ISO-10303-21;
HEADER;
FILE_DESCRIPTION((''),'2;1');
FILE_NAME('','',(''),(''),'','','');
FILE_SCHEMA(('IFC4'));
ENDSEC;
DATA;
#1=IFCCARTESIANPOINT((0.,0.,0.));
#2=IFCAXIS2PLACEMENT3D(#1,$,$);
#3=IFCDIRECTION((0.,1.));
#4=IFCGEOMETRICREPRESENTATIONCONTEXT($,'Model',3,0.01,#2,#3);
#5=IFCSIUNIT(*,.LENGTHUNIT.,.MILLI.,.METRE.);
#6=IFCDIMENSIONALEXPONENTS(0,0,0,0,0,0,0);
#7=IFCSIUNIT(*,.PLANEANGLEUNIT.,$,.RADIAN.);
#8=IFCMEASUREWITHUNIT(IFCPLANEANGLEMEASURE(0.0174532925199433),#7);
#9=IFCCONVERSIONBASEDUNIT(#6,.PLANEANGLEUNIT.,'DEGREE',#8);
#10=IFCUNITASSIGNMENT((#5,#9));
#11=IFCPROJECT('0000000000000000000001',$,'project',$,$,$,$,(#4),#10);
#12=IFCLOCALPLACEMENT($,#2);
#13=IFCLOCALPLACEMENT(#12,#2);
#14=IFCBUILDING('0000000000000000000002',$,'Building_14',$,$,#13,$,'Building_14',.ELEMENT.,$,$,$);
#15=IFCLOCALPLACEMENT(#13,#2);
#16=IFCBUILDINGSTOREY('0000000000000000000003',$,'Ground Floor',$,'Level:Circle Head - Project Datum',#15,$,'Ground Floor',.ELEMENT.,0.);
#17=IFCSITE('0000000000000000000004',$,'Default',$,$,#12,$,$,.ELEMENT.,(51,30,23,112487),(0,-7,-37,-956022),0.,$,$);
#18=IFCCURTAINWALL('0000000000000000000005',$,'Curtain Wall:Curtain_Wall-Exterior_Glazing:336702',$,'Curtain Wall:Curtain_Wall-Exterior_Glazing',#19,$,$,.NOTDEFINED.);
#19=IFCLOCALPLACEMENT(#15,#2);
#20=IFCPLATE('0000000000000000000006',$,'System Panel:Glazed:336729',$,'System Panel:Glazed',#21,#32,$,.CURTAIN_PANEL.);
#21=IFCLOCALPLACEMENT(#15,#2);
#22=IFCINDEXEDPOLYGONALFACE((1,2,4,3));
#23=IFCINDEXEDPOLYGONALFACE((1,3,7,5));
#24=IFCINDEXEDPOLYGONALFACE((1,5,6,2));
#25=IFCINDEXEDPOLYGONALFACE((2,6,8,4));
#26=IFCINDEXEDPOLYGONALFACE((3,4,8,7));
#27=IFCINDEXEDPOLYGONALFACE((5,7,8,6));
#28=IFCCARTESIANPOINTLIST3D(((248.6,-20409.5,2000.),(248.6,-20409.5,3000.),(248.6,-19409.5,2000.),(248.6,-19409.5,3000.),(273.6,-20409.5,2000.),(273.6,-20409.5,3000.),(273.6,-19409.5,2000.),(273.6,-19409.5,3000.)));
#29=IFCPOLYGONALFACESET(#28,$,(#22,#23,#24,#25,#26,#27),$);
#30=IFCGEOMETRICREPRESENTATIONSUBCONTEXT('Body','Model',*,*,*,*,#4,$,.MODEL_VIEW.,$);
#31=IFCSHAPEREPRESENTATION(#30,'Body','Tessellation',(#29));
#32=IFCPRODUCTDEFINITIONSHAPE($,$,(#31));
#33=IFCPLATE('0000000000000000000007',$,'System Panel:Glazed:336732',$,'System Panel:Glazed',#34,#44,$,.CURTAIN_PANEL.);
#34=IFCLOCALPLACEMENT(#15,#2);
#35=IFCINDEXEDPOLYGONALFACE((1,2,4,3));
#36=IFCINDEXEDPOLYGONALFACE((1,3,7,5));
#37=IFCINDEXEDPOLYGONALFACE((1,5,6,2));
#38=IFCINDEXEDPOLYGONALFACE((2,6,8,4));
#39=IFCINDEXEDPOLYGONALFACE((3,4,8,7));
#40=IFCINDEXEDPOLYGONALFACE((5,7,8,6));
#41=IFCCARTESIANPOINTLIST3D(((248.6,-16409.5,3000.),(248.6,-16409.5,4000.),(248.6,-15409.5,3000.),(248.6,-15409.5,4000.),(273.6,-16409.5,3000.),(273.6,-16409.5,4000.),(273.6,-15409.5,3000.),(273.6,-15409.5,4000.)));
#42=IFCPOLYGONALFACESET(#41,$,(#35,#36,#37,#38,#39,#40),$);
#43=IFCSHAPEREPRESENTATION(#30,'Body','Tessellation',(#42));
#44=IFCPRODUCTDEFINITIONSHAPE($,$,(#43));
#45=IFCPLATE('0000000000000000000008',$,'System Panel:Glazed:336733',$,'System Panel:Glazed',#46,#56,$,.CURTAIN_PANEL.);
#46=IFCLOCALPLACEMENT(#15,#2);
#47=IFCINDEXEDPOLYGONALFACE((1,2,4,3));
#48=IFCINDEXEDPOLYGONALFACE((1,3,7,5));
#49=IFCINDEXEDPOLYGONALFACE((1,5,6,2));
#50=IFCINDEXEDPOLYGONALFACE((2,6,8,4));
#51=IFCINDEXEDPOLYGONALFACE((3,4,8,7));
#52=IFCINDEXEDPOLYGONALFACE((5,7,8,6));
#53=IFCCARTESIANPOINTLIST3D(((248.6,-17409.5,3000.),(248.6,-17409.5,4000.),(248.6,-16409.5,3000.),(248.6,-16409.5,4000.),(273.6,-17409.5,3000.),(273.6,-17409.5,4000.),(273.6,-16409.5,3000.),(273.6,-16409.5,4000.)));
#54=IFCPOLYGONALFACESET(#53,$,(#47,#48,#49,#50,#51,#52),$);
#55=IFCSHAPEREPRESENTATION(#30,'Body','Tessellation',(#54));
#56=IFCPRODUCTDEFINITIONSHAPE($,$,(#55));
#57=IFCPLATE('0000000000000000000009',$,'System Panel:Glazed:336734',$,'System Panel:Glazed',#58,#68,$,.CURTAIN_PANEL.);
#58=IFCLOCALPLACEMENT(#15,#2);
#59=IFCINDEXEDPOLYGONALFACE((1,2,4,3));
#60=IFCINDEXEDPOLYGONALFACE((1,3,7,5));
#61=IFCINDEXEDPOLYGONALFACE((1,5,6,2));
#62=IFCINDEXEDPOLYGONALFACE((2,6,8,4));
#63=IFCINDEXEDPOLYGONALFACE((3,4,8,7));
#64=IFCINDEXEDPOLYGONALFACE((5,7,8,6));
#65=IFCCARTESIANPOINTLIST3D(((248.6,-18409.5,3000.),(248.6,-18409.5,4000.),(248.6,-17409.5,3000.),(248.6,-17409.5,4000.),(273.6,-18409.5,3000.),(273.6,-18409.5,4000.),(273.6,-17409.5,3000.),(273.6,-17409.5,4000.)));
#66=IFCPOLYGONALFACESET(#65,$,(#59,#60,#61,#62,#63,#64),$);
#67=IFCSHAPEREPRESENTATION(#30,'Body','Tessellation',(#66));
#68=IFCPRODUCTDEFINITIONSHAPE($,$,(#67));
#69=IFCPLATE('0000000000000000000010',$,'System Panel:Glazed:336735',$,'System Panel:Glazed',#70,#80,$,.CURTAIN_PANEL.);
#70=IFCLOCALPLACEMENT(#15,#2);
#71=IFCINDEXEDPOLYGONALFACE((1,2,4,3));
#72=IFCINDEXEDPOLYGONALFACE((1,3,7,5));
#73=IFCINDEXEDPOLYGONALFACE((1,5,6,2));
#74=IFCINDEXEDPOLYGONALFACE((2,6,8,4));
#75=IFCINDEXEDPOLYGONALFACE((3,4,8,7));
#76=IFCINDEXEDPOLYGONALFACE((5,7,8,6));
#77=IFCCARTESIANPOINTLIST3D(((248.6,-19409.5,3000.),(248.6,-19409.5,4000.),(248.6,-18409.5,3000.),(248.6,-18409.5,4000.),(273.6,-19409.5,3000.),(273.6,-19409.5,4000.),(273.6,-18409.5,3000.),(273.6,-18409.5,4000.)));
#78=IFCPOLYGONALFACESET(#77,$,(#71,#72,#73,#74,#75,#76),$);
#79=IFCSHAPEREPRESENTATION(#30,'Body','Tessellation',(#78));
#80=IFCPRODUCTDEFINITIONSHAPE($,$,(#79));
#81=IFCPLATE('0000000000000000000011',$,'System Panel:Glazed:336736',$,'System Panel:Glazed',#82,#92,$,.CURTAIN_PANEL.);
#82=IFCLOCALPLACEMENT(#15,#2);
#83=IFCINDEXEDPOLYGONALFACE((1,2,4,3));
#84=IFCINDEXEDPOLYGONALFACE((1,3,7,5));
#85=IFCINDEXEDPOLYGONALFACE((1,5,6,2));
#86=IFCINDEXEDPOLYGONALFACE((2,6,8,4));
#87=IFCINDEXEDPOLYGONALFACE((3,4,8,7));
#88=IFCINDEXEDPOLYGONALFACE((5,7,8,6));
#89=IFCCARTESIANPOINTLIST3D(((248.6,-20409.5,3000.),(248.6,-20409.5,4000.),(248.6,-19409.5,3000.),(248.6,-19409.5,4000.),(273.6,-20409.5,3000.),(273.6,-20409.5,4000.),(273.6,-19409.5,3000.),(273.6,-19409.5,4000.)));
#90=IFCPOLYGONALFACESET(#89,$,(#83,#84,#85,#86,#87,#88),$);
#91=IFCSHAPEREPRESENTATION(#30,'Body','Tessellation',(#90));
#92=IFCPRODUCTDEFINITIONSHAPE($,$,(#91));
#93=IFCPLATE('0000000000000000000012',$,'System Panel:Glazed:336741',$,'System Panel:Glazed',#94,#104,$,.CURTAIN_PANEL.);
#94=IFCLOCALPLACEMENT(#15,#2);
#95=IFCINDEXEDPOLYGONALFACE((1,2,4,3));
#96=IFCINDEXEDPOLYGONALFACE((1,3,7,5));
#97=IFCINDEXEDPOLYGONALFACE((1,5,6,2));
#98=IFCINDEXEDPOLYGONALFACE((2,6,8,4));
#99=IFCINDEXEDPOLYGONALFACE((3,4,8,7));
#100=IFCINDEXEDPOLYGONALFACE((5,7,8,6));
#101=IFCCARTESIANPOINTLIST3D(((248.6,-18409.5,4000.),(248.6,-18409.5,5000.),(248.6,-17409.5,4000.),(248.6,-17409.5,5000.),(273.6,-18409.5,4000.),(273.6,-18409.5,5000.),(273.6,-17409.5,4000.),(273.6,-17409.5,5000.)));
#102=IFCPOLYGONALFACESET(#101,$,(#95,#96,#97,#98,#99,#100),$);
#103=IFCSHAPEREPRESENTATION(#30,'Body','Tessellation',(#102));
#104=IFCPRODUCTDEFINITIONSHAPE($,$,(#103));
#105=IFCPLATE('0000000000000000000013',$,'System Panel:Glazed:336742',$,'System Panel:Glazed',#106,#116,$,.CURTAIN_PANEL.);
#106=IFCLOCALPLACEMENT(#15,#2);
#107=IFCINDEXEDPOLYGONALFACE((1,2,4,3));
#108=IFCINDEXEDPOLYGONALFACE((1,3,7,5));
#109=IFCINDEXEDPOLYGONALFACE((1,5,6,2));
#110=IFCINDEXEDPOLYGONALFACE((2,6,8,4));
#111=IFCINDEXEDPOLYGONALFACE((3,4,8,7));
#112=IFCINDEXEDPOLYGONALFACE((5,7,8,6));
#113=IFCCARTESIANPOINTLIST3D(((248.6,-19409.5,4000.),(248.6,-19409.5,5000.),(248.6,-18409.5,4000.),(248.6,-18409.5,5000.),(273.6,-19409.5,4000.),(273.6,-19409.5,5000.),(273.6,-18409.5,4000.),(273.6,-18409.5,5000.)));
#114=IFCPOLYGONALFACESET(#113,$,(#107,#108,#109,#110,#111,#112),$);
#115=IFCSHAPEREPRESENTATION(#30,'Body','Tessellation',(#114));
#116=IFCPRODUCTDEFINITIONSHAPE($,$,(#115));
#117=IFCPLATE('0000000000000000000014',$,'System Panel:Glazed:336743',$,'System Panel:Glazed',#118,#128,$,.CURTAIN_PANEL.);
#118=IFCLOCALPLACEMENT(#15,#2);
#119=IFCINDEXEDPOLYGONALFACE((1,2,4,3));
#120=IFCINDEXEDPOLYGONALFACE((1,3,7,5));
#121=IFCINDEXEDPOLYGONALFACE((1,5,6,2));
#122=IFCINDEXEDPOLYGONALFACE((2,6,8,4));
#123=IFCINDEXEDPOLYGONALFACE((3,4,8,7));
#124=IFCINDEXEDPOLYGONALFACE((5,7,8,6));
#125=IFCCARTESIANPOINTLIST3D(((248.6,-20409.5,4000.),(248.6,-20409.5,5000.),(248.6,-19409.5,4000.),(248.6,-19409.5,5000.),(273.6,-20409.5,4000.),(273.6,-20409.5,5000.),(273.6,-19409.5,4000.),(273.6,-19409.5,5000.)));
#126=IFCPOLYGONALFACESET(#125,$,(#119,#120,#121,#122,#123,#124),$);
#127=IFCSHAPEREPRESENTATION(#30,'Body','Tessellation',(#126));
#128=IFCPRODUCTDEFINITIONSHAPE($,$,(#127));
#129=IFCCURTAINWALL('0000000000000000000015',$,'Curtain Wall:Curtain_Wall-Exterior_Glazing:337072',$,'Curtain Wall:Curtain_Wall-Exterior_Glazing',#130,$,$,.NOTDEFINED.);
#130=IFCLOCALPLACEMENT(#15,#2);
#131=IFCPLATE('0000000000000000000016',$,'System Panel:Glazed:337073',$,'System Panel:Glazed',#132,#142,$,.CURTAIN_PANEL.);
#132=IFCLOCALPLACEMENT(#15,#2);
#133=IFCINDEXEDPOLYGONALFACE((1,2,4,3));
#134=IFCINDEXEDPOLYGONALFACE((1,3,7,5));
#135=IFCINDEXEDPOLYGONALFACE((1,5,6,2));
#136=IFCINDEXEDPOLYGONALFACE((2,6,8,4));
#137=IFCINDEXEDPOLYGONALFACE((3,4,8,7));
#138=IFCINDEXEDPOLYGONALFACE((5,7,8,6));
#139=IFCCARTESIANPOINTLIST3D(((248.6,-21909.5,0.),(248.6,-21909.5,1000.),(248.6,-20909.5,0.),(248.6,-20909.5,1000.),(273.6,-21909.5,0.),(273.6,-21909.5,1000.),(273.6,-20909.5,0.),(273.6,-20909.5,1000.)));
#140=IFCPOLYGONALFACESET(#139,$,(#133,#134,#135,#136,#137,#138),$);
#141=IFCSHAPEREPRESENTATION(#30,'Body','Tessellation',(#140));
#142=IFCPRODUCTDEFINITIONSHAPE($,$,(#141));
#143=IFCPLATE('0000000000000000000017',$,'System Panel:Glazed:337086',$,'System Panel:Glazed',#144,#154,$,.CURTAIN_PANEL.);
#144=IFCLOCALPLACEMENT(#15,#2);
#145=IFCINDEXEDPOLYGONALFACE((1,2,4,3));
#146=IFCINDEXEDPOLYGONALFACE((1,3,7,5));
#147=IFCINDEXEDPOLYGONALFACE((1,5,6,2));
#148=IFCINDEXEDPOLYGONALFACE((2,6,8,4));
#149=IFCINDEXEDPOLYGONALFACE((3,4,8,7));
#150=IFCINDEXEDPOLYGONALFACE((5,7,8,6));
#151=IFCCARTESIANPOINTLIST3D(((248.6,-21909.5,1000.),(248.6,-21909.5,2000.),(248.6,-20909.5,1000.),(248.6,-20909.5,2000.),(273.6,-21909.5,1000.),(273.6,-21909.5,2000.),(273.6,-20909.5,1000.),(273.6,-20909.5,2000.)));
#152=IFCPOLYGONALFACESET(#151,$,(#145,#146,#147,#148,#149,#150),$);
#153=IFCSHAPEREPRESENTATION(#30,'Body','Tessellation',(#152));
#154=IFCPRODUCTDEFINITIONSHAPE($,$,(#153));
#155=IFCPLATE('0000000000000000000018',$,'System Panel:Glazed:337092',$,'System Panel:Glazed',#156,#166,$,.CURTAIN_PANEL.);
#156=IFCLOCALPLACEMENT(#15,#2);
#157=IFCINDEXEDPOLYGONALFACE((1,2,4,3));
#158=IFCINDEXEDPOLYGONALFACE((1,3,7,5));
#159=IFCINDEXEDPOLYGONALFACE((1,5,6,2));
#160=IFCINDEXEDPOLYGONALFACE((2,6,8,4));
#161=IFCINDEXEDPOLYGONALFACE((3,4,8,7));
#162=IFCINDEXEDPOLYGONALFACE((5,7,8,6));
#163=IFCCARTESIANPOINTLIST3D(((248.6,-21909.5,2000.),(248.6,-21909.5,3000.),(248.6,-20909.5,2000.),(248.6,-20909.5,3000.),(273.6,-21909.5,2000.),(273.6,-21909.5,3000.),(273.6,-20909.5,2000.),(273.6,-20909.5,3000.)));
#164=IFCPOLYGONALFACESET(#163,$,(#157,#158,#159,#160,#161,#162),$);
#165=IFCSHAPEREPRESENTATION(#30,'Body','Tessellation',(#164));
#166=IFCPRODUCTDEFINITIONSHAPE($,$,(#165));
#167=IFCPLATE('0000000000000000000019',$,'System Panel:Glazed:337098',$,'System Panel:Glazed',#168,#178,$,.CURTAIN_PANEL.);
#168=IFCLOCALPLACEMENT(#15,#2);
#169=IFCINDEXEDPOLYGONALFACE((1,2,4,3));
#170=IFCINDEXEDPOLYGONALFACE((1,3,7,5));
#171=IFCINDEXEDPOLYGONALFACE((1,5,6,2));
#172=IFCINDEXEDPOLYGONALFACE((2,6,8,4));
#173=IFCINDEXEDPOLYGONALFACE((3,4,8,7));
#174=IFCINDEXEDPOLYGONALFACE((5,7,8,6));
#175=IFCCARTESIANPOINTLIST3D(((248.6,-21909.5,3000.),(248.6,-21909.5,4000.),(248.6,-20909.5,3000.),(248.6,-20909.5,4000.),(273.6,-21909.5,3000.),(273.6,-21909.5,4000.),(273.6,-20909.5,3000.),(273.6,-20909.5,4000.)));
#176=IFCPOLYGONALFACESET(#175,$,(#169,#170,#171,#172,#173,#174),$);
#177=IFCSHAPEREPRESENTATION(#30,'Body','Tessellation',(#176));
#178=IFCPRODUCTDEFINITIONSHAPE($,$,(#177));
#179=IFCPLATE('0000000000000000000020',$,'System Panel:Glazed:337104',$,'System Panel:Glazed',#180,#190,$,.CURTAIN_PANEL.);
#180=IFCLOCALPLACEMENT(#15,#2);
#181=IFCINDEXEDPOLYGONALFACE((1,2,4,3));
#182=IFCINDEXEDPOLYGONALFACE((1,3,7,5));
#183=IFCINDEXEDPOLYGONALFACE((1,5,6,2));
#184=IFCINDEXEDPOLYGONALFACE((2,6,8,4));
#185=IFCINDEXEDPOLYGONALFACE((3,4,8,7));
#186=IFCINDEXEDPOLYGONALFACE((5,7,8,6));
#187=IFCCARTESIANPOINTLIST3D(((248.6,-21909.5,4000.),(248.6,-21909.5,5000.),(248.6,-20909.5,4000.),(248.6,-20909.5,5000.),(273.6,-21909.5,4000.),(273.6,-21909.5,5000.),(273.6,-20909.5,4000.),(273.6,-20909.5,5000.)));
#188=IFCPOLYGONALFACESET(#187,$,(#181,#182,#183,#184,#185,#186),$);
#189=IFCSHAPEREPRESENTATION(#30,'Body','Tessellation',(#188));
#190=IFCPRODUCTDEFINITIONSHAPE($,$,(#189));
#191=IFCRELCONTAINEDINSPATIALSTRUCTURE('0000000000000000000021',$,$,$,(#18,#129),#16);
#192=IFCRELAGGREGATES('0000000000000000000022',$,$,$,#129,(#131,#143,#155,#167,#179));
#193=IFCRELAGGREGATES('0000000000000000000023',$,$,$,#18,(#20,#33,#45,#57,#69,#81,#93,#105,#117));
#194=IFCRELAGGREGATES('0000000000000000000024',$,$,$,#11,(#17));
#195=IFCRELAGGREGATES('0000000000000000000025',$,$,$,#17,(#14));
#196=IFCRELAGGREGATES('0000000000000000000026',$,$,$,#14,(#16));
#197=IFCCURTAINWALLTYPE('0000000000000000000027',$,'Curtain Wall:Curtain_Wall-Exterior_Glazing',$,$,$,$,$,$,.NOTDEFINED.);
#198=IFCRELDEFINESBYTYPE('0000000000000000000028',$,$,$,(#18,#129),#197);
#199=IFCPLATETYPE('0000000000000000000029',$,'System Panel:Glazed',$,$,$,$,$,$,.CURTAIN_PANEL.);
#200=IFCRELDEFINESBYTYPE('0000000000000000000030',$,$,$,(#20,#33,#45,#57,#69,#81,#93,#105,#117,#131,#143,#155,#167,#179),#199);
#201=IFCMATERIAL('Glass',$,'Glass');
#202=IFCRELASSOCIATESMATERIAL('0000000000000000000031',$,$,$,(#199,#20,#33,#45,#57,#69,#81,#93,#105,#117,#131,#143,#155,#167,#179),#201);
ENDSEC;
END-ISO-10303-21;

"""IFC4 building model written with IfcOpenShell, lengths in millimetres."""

from ifc_helpers import new_model, entity, si_unit, converted_unit, direction, frame, origin, place, context, subcontext, project, spatial, indexed_curve, outline, extrude, source, transform, mapped, material, type_object, type_shapes, element, aggregate, save


model = new_model("IFC4")

# Units and contexts
model_context = context("Model", 3, precision=0.01, world=origin(), true_north=direction((0.0, 1.0)))
body_context = subcontext(model_context, "Body", "Model", "MODEL_VIEW")
ifc_project = project(units=[si_unit("LENGTHUNIT", "METRE", prefix="MILLI"), converted_unit("PLANEANGLEUNIT", "DEGREE", entity("IfcPlaneAngleMeasure", 0.0174532925199433), si_unit("PLANEANGLEUNIT", "RADIAN"), dimensions=[0, 0, 0, 0, 0, 0, 0])], contexts=[model_context])

# Site, building, storey
site_placement = place(None, origin())
site = spatial("IfcSite", under=ifc_project, at=site_placement, Name="Default", CompositionType="ELEMENT", RefLatitude=(51, 30, 23, 112487), RefLongitude=(0, -7, -37, -956022), RefElevation=0.0)
building_placement = place(site_placement, origin())
building = spatial("IfcBuilding", under=site, at=building_placement, Name="Building_14", LongName="Building_14", CompositionType="ELEMENT")
storey_placement = place(building_placement, origin())
storey = spatial("IfcBuildingStorey", under=building, at=storey_placement, Name="Ground Floor", ObjectType="Level:Circle Head - Project Datum", LongName="Ground Floor", CompositionType="ELEMENT", Elevation=0.0)

# Curtain walls, plates
curtain_wall_type = type_object("IfcCurtainWallType", Name="Curtain Wall:Curtain_Wall-Exterior_Glazing", PredefinedType="NOTDEFINED")
curtain_wall_1_placement = place(storey_placement, origin())
curtain_wall_1 = element("IfcCurtainWall", 1, at=curtain_wall_1_placement, inside=storey, type_object=curtain_wall_type, Name="Curtain Wall:Curtain_Wall-Exterior_Glazing:336702", ObjectType="Curtain Wall:Curtain_Wall-Exterior_Glazing", PredefinedType="NOTDEFINED")
ifc_material = material(Name="Glass", Category="Glass")
plate_type_1 = type_object("IfcPlateType", Name="System Panel:Glazed", PredefinedType="CURTAIN_PANEL", material=ifc_material)
shared_shape_1 = source(origin(), body_context, "Body", "SweptSolid", [
    extrude(outline(indexed_curve([(-12.5, -500.0), (12.5, -500.0), (12.5, 500.0), (-12.5, 500.0), (-12.5, -500.0)], self_intersect=False)), frame((0.0, -37.0, 0.0), z_axis=(0.0, 0.0, 1.0), x_axis=(0.0, 1.0, 0.0)), (0.0, 0.0, 1.0), 1000.0),
])
type_shapes(plate_type_1, [shared_shape_1])
plate_1_placement = place(curtain_wall_1_placement, frame((298.1, -19909.5, 2000.0), z_axis=(0.0, 0.0, 1.0), x_axis=(0.0, -1.0, 0.0)))
plate_1 = element("IfcPlate", 2, at=plate_1_placement, type_object=plate_type_1, material=ifc_material, Name="System Panel:Glazed:336729", ObjectType="System Panel:Glazed", PredefinedType="CURTAIN_PANEL", context=body_context, shape_type="MappedRepresentation", body=[
    mapped(shared_shape_1, transform((0.0, 0.0, 0.0), scale=1.0)),
])
plate_2_placement = place(curtain_wall_1_placement, frame((298.1, -15909.5, 3000.0), z_axis=(0.0, 0.0, 1.0), x_axis=(0.0, -1.0, 0.0)))
plate_2 = element("IfcPlate", 3, at=plate_2_placement, type_object=plate_type_1, material=ifc_material, Name="System Panel:Glazed:336732", ObjectType="System Panel:Glazed", PredefinedType="CURTAIN_PANEL", context=body_context, shape_type="MappedRepresentation", body=[
    mapped(shared_shape_1, transform((0.0, 0.0, 0.0), scale=1.0)),
])
plate_3_placement = place(curtain_wall_1_placement, frame((298.1, -16909.5, 3000.0), z_axis=(0.0, 0.0, 1.0), x_axis=(0.0, -1.0, 0.0)))
plate_3 = element("IfcPlate", 4, at=plate_3_placement, type_object=plate_type_1, material=ifc_material, Name="System Panel:Glazed:336733", ObjectType="System Panel:Glazed", PredefinedType="CURTAIN_PANEL", context=body_context, shape_type="MappedRepresentation", body=[
    mapped(shared_shape_1, transform((0.0, 0.0, 0.0), scale=1.0)),
])
plate_4_placement = place(curtain_wall_1_placement, frame((298.1, -17909.5, 3000.0), z_axis=(0.0, 0.0, 1.0), x_axis=(0.0, -1.0, 0.0)))
plate_4 = element("IfcPlate", 5, at=plate_4_placement, type_object=plate_type_1, material=ifc_material, Name="System Panel:Glazed:336734", ObjectType="System Panel:Glazed", PredefinedType="CURTAIN_PANEL", context=body_context, shape_type="MappedRepresentation", body=[
    mapped(shared_shape_1, transform((0.0, 0.0, 0.0), scale=1.0)),
])
plate_5_placement = place(curtain_wall_1_placement, frame((298.1, -18909.5, 3000.0), z_axis=(0.0, 0.0, 1.0), x_axis=(0.0, -1.0, 0.0)))
plate_5 = element("IfcPlate", 6, at=plate_5_placement, type_object=plate_type_1, material=ifc_material, Name="System Panel:Glazed:336735", ObjectType="System Panel:Glazed", PredefinedType="CURTAIN_PANEL", context=body_context, shape_type="MappedRepresentation", body=[
    mapped(shared_shape_1, transform((0.0, 0.0, 0.0), scale=1.0)),
])
plate_6_placement = place(curtain_wall_1_placement, frame((298.1, -19909.5, 3000.0), z_axis=(0.0, 0.0, 1.0), x_axis=(0.0, -1.0, 0.0)))
plate_6 = element("IfcPlate", 7, at=plate_6_placement, type_object=plate_type_1, material=ifc_material, Name="System Panel:Glazed:336736", ObjectType="System Panel:Glazed", PredefinedType="CURTAIN_PANEL", context=body_context, shape_type="MappedRepresentation", body=[
    mapped(shared_shape_1, transform((0.0, 0.0, 0.0), scale=1.0)),
])
plate_7_placement = place(curtain_wall_1_placement, frame((298.1, -17909.5, 4000.0), z_axis=(0.0, 0.0, 1.0), x_axis=(0.0, -1.0, 0.0)))
plate_7 = element("IfcPlate", 8, at=plate_7_placement, type_object=plate_type_1, material=ifc_material, Name="System Panel:Glazed:336741", ObjectType="System Panel:Glazed", PredefinedType="CURTAIN_PANEL", context=body_context, shape_type="MappedRepresentation", body=[
    mapped(shared_shape_1, transform((0.0, 0.0, 0.0), scale=1.0)),
])
plate_8_placement = place(curtain_wall_1_placement, frame((298.1, -18909.5, 4000.0), z_axis=(0.0, 0.0, 1.0), x_axis=(0.0, -1.0, 0.0)))
plate_8 = element("IfcPlate", 9, at=plate_8_placement, type_object=plate_type_1, material=ifc_material, Name="System Panel:Glazed:336742", ObjectType="System Panel:Glazed", PredefinedType="CURTAIN_PANEL", context=body_context, shape_type="MappedRepresentation", body=[
    mapped(shared_shape_1, transform((0.0, 0.0, 0.0), scale=1.0)),
])
plate_9_placement = place(curtain_wall_1_placement, frame((298.1, -19909.5, 4000.0), z_axis=(0.0, 0.0, 1.0), x_axis=(0.0, -1.0, 0.0)))
plate_9 = element("IfcPlate", 10, at=plate_9_placement, type_object=plate_type_1, material=ifc_material, Name="System Panel:Glazed:336743", ObjectType="System Panel:Glazed", PredefinedType="CURTAIN_PANEL", context=body_context, shape_type="MappedRepresentation", body=[
    mapped(shared_shape_1, transform((0.0, 0.0, 0.0), scale=1.0)),
])
curtain_wall_2_placement = place(storey_placement, origin())
curtain_wall_2 = element("IfcCurtainWall", 11, at=curtain_wall_2_placement, inside=storey, type_object=curtain_wall_type, Name="Curtain Wall:Curtain_Wall-Exterior_Glazing:337072", ObjectType="Curtain Wall:Curtain_Wall-Exterior_Glazing", PredefinedType="NOTDEFINED")
plate_10_placement = place(curtain_wall_2_placement, frame((298.1, -21409.5, 0.0), z_axis=(0.0, 0.0, 1.0), x_axis=(0.0, -1.0, 0.0)))
plate_10 = element("IfcPlate", 12, at=plate_10_placement, type_object=plate_type_1, material=ifc_material, Name="System Panel:Glazed:337073", ObjectType="System Panel:Glazed", PredefinedType="CURTAIN_PANEL", context=body_context, shape_type="MappedRepresentation", body=[
    mapped(shared_shape_1, transform((0.0, 0.0, 0.0), scale=1.0)),
])
plate_11_placement = place(curtain_wall_2_placement, frame((298.1, -21409.5, 1000.0), z_axis=(0.0, 0.0, 1.0), x_axis=(0.0, -1.0, 0.0)))
plate_11 = element("IfcPlate", 13, at=plate_11_placement, type_object=plate_type_1, material=ifc_material, Name="System Panel:Glazed:337086", ObjectType="System Panel:Glazed", PredefinedType="CURTAIN_PANEL", context=body_context, shape_type="MappedRepresentation", body=[
    mapped(shared_shape_1, transform((0.0, 0.0, 0.0), scale=1.0)),
])
plate_12_placement = place(curtain_wall_2_placement, frame((298.1, -21409.5, 2000.0), z_axis=(0.0, 0.0, 1.0), x_axis=(0.0, -1.0, 0.0)))
plate_12 = element("IfcPlate", 14, at=plate_12_placement, type_object=plate_type_1, material=ifc_material, Name="System Panel:Glazed:337092", ObjectType="System Panel:Glazed", PredefinedType="CURTAIN_PANEL", context=body_context, shape_type="MappedRepresentation", body=[
    mapped(shared_shape_1, transform((0.0, 0.0, 0.0), scale=1.0)),
])
plate_13_placement = place(curtain_wall_2_placement, frame((298.1, -21409.5, 3000.0), z_axis=(0.0, 0.0, 1.0), x_axis=(0.0, -1.0, 0.0)))
plate_13 = element("IfcPlate", 15, at=plate_13_placement, type_object=plate_type_1, material=ifc_material, Name="System Panel:Glazed:337098", ObjectType="System Panel:Glazed", PredefinedType="CURTAIN_PANEL", context=body_context, shape_type="MappedRepresentation", body=[
    mapped(shared_shape_1, transform((0.0, 0.0, 0.0), scale=1.0)),
])
plate_14_placement = place(curtain_wall_2_placement, frame((298.1, -21409.5, 4000.0), z_axis=(0.0, 0.0, 1.0), x_axis=(0.0, -1.0, 0.0)))
plate_14 = element("IfcPlate", 16, at=plate_14_placement, type_object=plate_type_1, material=ifc_material, Name="System Panel:Glazed:337104", ObjectType="System Panel:Glazed", PredefinedType="CURTAIN_PANEL", context=body_context, shape_type="MappedRepresentation", body=[
    mapped(shared_shape_1, transform((0.0, 0.0, 0.0), scale=1.0)),
])
aggregate(curtain_wall_2, [plate_10, plate_11, plate_12, plate_13, plate_14])

aggregate(curtain_wall_1, [plate_1, plate_2, plate_3, plate_4, plate_5, plate_6, plate_7, plate_8, plate_9])

save(model, "model.ifc")
